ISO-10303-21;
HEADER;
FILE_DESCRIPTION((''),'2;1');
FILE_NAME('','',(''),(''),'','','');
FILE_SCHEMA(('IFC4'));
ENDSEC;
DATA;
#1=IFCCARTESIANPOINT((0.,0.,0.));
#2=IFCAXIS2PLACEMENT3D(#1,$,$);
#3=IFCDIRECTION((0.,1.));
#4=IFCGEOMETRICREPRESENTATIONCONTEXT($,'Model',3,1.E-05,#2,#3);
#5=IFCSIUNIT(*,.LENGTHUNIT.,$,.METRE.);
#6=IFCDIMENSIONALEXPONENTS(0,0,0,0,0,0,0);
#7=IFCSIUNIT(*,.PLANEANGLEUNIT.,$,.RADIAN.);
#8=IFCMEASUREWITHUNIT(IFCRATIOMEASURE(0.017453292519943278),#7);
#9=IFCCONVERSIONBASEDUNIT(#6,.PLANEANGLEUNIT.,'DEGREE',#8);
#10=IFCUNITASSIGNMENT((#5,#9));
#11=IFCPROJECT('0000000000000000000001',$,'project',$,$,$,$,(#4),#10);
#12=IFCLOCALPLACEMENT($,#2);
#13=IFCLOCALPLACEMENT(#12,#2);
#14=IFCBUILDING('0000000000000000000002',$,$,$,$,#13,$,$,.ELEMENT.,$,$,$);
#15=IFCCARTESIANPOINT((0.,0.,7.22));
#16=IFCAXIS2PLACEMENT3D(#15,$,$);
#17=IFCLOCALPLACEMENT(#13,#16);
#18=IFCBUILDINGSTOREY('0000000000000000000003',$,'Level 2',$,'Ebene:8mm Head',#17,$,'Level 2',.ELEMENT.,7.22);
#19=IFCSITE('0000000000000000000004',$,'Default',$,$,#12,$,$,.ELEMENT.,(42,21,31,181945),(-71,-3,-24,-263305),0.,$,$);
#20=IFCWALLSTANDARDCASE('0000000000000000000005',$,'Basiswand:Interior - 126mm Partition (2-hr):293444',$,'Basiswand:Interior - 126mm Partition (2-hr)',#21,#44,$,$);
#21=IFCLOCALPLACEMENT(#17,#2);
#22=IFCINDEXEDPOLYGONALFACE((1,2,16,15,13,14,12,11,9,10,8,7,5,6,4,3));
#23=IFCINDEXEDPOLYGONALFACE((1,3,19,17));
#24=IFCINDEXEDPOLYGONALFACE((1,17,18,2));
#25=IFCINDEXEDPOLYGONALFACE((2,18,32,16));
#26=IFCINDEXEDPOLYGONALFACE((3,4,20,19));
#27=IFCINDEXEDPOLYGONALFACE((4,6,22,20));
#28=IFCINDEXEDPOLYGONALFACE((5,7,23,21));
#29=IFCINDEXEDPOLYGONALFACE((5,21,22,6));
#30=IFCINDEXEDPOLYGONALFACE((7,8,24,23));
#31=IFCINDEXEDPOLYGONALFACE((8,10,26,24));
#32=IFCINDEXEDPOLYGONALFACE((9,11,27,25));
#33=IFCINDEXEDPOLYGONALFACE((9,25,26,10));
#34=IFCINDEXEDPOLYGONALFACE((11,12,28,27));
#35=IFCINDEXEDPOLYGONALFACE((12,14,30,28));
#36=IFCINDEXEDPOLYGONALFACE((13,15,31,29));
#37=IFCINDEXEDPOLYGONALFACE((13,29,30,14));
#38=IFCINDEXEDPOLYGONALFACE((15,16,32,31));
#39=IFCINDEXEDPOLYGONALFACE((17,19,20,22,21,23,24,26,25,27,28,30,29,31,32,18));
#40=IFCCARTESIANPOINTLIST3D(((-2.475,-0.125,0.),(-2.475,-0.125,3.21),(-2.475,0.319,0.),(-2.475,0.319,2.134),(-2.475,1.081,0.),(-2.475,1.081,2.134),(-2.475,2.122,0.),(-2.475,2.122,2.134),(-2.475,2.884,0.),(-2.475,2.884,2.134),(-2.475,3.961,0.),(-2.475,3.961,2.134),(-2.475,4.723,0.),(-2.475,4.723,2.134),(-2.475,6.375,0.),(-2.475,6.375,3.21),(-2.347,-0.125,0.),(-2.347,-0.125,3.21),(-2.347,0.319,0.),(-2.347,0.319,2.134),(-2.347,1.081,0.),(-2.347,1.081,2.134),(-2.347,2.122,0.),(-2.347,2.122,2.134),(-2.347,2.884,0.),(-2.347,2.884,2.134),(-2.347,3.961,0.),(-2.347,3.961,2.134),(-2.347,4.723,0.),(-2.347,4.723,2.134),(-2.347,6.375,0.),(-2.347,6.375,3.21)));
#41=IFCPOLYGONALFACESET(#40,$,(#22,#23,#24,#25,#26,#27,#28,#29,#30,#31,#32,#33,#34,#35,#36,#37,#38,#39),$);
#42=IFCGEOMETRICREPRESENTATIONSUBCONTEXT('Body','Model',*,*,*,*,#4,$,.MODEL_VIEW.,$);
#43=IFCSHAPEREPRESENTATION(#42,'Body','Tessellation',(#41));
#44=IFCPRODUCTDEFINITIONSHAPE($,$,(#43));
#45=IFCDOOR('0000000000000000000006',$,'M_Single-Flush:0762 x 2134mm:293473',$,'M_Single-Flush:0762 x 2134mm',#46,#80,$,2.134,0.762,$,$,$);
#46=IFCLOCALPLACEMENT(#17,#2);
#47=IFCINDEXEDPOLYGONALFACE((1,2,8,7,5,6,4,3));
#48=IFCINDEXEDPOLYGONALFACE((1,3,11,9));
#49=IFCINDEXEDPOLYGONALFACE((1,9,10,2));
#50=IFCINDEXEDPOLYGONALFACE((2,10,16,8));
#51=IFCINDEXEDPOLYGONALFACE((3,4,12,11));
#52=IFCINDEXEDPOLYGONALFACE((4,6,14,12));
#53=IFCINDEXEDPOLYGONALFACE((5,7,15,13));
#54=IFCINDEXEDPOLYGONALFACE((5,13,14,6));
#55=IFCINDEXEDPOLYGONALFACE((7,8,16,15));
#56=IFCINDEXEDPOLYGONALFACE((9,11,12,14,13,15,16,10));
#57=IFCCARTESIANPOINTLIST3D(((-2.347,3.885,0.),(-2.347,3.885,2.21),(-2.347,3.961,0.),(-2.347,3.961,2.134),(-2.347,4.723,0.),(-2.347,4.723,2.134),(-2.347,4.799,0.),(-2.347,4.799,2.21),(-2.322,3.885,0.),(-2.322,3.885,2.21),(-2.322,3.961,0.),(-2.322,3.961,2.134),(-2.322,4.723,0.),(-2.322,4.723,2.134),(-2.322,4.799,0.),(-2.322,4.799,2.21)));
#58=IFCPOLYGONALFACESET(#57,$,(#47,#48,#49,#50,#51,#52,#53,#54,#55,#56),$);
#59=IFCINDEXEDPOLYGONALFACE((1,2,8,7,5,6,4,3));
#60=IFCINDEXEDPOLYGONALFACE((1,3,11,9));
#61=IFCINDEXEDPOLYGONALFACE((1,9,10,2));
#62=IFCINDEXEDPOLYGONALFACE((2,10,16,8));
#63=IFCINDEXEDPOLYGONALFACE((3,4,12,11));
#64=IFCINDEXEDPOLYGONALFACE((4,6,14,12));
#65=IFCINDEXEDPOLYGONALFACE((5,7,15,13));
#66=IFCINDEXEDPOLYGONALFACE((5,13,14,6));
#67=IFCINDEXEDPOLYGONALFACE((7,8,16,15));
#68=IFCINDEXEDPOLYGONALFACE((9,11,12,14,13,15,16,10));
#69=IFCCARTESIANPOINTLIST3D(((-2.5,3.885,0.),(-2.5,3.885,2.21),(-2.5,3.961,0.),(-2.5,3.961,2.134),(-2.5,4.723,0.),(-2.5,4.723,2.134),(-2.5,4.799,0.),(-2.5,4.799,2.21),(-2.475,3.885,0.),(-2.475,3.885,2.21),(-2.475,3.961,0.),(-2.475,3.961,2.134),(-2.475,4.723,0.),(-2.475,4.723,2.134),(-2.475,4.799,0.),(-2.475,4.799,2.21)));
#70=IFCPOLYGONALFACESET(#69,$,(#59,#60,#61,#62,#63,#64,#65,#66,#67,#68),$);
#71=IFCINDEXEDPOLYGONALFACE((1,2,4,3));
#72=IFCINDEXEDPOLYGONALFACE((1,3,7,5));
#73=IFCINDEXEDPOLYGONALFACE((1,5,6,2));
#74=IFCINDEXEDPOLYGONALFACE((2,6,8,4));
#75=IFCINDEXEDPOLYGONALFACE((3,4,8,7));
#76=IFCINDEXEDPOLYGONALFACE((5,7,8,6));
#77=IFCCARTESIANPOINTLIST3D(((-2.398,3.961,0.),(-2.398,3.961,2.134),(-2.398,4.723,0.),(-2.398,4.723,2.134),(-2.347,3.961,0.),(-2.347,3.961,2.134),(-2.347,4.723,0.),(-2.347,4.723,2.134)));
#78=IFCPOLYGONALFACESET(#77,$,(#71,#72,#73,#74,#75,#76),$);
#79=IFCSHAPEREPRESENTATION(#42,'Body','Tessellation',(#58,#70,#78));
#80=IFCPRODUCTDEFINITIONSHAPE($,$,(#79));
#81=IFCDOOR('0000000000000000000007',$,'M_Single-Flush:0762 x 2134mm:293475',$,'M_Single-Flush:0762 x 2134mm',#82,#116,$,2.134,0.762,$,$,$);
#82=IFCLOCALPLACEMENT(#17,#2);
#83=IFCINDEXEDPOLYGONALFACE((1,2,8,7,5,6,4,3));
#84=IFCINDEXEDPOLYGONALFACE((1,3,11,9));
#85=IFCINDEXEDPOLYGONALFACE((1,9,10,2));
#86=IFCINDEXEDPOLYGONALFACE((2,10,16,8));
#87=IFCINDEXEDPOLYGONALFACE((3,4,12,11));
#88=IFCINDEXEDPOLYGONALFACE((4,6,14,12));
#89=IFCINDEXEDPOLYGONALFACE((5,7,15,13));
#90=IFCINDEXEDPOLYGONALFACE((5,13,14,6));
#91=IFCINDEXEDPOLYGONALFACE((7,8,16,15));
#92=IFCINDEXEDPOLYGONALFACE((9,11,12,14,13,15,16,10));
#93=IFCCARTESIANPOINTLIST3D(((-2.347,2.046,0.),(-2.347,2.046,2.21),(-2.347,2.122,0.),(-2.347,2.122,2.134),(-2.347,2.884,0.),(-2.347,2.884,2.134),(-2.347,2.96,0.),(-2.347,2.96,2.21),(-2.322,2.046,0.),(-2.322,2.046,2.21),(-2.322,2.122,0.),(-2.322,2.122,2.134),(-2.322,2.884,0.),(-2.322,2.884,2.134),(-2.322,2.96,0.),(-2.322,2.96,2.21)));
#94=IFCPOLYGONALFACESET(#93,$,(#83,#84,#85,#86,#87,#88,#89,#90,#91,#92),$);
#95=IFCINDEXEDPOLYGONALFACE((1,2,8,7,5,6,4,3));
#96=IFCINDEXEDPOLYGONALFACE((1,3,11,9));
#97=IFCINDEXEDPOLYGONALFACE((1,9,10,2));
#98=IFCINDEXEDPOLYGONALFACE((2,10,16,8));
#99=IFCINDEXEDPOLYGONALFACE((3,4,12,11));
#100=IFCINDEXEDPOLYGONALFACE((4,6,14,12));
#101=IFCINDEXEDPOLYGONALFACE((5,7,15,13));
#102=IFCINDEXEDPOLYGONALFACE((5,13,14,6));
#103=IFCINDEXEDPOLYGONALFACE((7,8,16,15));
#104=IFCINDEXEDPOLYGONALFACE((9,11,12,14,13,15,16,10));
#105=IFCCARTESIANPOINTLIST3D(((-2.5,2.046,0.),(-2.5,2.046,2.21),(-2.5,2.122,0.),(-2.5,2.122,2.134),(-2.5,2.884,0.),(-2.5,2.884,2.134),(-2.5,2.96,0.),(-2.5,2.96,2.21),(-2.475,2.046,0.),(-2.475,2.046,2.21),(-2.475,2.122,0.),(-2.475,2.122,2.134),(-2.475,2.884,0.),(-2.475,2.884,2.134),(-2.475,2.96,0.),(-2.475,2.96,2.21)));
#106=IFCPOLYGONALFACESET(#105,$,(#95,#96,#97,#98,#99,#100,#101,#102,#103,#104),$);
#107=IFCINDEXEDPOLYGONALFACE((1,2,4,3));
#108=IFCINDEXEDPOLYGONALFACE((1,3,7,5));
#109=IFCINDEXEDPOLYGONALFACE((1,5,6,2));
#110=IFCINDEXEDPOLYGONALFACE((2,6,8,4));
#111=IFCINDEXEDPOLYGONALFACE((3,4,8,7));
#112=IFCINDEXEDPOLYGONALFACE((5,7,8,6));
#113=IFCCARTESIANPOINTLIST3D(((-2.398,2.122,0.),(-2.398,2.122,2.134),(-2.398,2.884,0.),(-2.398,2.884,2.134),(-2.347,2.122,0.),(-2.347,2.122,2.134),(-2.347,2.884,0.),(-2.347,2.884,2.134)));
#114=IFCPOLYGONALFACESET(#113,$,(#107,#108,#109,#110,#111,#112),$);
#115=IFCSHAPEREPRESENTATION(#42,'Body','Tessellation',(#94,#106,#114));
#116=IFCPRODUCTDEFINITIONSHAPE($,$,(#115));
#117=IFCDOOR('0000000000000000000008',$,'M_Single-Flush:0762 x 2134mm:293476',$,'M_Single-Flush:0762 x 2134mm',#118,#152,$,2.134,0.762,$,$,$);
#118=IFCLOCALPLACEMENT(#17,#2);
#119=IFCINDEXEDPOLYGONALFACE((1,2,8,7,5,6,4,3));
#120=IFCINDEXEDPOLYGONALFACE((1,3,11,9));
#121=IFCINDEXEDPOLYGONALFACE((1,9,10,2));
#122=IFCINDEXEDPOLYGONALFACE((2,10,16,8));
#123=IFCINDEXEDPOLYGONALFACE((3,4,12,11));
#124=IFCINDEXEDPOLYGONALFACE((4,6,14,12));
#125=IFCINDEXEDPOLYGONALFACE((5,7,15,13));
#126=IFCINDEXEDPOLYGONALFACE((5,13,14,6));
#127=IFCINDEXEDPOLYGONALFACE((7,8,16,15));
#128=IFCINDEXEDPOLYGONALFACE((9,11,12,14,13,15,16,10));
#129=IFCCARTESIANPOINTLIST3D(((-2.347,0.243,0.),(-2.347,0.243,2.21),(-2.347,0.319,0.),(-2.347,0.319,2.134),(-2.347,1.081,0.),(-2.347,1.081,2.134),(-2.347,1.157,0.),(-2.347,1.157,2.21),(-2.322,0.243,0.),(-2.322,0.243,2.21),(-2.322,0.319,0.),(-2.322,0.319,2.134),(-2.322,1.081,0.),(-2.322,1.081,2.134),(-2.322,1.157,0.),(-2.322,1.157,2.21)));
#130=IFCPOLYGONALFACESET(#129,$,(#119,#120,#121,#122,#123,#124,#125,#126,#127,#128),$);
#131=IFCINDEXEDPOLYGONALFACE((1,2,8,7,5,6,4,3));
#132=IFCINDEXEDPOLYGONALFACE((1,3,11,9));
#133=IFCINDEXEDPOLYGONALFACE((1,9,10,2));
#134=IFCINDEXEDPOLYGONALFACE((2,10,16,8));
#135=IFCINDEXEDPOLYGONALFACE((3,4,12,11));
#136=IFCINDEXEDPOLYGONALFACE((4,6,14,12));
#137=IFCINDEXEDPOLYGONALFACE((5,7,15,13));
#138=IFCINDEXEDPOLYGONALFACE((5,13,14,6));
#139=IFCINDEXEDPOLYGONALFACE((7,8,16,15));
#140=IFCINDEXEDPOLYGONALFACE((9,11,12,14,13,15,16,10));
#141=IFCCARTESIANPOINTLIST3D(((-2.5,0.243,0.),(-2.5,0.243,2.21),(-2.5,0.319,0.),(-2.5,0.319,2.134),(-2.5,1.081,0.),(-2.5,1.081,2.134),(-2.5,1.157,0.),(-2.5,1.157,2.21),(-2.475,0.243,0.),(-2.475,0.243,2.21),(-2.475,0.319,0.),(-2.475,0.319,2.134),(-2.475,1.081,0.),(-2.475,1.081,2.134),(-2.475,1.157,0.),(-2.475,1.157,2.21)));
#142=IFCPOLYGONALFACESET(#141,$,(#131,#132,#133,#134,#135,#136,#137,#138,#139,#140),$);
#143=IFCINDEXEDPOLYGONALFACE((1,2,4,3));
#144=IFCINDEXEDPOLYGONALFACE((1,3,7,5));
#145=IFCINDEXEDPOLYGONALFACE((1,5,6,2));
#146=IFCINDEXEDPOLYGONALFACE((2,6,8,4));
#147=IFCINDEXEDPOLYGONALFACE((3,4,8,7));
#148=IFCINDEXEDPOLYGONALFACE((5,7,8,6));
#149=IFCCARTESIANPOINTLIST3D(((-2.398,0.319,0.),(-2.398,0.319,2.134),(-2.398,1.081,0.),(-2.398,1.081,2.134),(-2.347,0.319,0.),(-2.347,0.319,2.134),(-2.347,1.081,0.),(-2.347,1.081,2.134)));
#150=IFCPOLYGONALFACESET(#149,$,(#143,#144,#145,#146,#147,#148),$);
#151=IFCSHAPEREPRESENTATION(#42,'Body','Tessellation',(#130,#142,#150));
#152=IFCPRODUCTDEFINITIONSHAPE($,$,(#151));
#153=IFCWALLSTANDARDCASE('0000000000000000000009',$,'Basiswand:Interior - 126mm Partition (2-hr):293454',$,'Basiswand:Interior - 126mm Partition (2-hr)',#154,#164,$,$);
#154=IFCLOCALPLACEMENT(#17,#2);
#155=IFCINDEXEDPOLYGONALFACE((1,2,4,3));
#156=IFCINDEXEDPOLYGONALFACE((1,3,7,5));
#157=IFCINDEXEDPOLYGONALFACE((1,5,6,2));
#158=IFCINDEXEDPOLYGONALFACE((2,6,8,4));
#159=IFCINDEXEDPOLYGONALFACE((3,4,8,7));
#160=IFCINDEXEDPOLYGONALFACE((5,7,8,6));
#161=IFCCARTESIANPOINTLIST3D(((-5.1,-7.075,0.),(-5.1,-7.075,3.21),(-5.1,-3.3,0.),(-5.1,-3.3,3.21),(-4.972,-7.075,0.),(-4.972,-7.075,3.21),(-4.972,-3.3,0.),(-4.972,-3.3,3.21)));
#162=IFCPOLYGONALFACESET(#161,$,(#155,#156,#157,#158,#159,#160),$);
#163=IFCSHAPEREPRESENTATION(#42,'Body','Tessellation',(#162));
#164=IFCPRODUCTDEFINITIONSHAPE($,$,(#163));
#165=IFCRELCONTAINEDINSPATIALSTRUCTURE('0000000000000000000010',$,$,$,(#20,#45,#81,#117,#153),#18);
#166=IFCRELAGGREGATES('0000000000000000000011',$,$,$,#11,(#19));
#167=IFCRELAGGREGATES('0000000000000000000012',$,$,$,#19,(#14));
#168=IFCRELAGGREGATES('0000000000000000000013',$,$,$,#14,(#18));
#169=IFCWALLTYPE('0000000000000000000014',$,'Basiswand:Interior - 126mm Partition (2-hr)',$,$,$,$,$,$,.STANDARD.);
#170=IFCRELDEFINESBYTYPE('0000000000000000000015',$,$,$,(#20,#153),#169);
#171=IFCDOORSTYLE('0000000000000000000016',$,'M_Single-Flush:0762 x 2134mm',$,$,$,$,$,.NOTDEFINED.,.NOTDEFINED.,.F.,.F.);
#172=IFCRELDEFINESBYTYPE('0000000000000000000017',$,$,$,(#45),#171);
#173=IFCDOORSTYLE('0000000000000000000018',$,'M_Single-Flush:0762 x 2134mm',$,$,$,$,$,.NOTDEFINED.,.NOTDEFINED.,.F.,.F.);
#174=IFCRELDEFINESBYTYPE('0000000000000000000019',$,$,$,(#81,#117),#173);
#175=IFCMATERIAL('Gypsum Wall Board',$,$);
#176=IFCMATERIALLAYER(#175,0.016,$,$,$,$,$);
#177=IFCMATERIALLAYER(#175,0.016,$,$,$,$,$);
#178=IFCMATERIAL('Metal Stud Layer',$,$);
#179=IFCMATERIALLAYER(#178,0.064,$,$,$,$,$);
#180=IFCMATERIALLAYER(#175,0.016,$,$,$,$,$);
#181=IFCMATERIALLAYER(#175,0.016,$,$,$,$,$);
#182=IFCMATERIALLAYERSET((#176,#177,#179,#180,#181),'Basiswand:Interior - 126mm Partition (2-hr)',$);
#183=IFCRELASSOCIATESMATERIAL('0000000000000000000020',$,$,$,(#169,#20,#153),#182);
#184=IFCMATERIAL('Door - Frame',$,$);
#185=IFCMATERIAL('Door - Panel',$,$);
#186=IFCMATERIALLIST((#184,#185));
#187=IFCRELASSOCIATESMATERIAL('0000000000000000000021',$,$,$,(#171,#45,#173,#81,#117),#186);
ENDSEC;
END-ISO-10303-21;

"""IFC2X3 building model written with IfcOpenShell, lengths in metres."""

from ifc_helpers import new_model, entity, si_unit, converted_unit, direction, frame, frame_2d, origin, place, context, subcontext, project, spatial, polyline, rectangle, outline, extrude, clip, bounded_halfspace, source, transform, mapped, material, material_list, layer, layer_set, layer_usage, type_object, type_shapes, element, fill, save


model = new_model("IFC2X3")

# Units and contexts
model_context = context("Model", 3, precision=1e-05, world=origin(), true_north=direction((0.0, 1.0)))
body_context = subcontext(model_context, "Body", "Model", "MODEL_VIEW")
ifc_project = project(units=[si_unit("LENGTHUNIT", "METRE"), converted_unit("PLANEANGLEUNIT", "DEGREE", entity("IfcRatioMeasure", 0.017453292519943278), si_unit("PLANEANGLEUNIT", "RADIAN"), dimensions=[0, 0, 0, 0, 0, 0, 0])], contexts=[model_context])

# Site, building, storey
site_placement = place(None, origin())
site = spatial("IfcSite", under=ifc_project, at=site_placement, Name="Default", CompositionType="ELEMENT", RefLatitude=(42, 21, 31, 181945), RefLongitude=(-71, -3, -24, -263305), RefElevation=0.0)
building_placement = place(site_placement, origin())
building = spatial("IfcBuilding", under=site, at=building_placement, CompositionType="ELEMENT")
storey_placement = place(building_placement, frame((0.0, 0.0, 7.22)))
storey = spatial("IfcBuildingStorey", under=building, at=storey_placement, Name="Level 2", ObjectType="Ebene:8mm Head", LongName="Level 2", CompositionType="ELEMENT", Elevation=7.22)

# Shared definitions
ifc_material_1 = material(Name="Gypsum Wall Board")
ifc_layer_1 = layer(ifc_material_1, 0.016)
ifc_layer_2 = layer(ifc_material_1, 0.016)
ifc_material_2 = material(Name="Metal Stud Layer")
ifc_layer_3 = layer(ifc_material_2, 0.064)
ifc_layer_4 = layer(ifc_material_1, 0.016)
ifc_layer_5 = layer(ifc_material_1, 0.016)
ifc_layer_set_1 = layer_set([ifc_layer_1, ifc_layer_2, ifc_layer_3, ifc_layer_4, ifc_layer_5], Name="Basiswand:Interior - 126mm Partition (2-hr)")
wall_type_1 = type_object("IfcWallType", Name="Basiswand:Interior - 126mm Partition (2-hr)", PredefinedType="STANDARD", material=ifc_layer_set_1)
ifc_material_3 = material(Name="Door - Frame")
ifc_material_4 = material(Name="Door - Panel")
ifc_material_list = material_list([ifc_material_3, ifc_material_4])

# Wall, openings, doors
ifc_layer_usage_1 = layer_usage(ifc_layer_set_1, "AXIS2", "NEGATIVE", 0.064)
wall_1_placement = place(storey_placement, frame((-2.411, -0.125, 0.0), z_axis=(0.0, 0.0, 1.0), x_axis=(0.0, 1.0, 0.0)))
wall_1 = element("IfcWallStandardCase", 1, at=wall_1_placement, inside=storey, type_object=wall_type_1, material=ifc_layer_usage_1, Name="Basiswand:Interior - 126mm Partition (2-hr):293444", ObjectType="Basiswand:Interior - 126mm Partition (2-hr)", context=body_context, shape_type="Clipping", body=[
    clip(extrude(rectangle(XDim=6.5, YDim=0.128, at=frame_2d((3.25, 0.0), x_axis=(1.0, 0.0))), origin(), (0.0, 0.0, 1.0), 3.21), bounded_halfspace(frame((0.0, -0.064, 3.21), z_axis=(0.0, 0.0, -1.0), x_axis=(1.0, 0.0, 0.0)), True, frame((0.0, -0.064, 3.21)), polyline([(0.0, 0.0), (2.0, 0.0), (2.128, 0.0), (3.128, 0.0), (3.256, 0.0), (5.103, 0.0), (5.231, 0.0), (6.5, 0.0), (6.5, 0.128), (0.0, 0.128), (0.0, 0.0)]))),
])
opening_1_placement = place(wall_1_placement, frame((4.848, 0.064, 0.0)))
opening_1 = element("IfcOpeningElement", 2, at=opening_1_placement, cuts=wall_1, ObjectType="Opening", context=body_context, shape_type="SweptSolid", body=[
    extrude(rectangle(XDim=0.762, YDim=2.134, at=frame_2d((1.067, 0.381), x_axis=(0.0, -1.0))), frame((0.0, 0.0, 0.0), z_axis=(0.0, -1.0, 0.0), x_axis=(0.0, 0.0, 1.0)), (0.0, 0.0, 1.0), 0.128),
])
opening_2_placement = place(wall_1_placement, frame((3.009, 0.064, 0.0)))
opening_2 = element("IfcOpeningElement", 3, at=opening_2_placement, cuts=wall_1, ObjectType="Opening", context=body_context, shape_type="SweptSolid", body=[
    extrude(rectangle(XDim=0.762, YDim=2.134, at=frame_2d((1.067, 0.381), x_axis=(0.0, 1.0))), frame((0.0, 0.0, 0.0), z_axis=(0.0, -1.0, 0.0), x_axis=(0.0, 0.0, 1.0)), (0.0, 0.0, 1.0), 0.128),
])
opening_3_placement = place(wall_1_placement, frame((1.206, 0.064, 0.0)))
opening_3 = element("IfcOpeningElement", 4, at=opening_3_placement, cuts=wall_1, ObjectType="Opening", context=body_context, shape_type="SweptSolid", body=[
    extrude(rectangle(XDim=0.762, YDim=2.134, at=frame_2d((1.067, 0.381), x_axis=(0.0, 1.0))), frame((0.0, 0.0, 0.0), z_axis=(0.0, -1.0, 0.0), x_axis=(0.0, 0.0, 1.0)), (0.0, 0.0, 1.0), 0.128),
])
door_style_1 = type_object("IfcDoorStyle", Name="M_Single-Flush:0762 x 2134mm", ConstructionType="NOTDEFINED", OperationType="NOTDEFINED", ParameterTakesPrecedence=False, Sizeable=False, material=ifc_material_list)
shared_shape_1 = source(origin(), body_context, "Body", "SweptSolid", [
    extrude(outline(polyline([(-0.457, -1.124), (0.457, -1.124), (0.457, 1.086), (0.381, 1.086), (0.381, -1.048), (-0.381, -1.048), (-0.381, 1.086), (-0.457, 1.086), (-0.457, -1.124)])), frame((0.381, 0.153, 1.086), z_axis=(0.0, -1.0, 0.0), x_axis=(-1.0, 0.0, 0.0)), (0.0, 0.0, 1.0), 0.025),
    extrude(outline(polyline([(-1.124, -0.457), (1.086, -0.457), (1.086, -0.381), (-1.048, -0.381), (-1.048, 0.381), (1.086, 0.381), (1.086, 0.457), (-1.124, 0.457), (-1.124, -0.457)])), frame((0.381, 0.0, 1.086), z_axis=(0.0, -1.0, 0.0), x_axis=(0.0, 0.0, -1.0)), (0.0, 0.0, 1.0), 0.025),
    extrude(rectangle(XDim=0.762, YDim=0.051, at=frame_2d((0.0, 0.0), x_axis=(1.0, 0.0))), frame((0.381, 0.1025, 0.0)), (0.0, 0.0, 1.0), 2.134),
])
type_shapes(door_style_1, [shared_shape_1])
door_1_placement = place(opening_1_placement, frame((0.0, 0.0, 0.0), z_axis=(0.0, 0.0, 1.0), x_axis=(-1.0, 0.0, 0.0)))
door_1 = element("IfcDoor", 5, at=door_1_placement, inside=storey, type_object=door_style_1, material=ifc_material_list, Name="M_Single-Flush:0762 x 2134mm:293473", ObjectType="M_Single-Flush:0762 x 2134mm", OverallHeight=2.134, OverallWidth=0.762, context=body_context, shape_type="MappedRepresentation", body=[
    mapped(shared_shape_1, transform((0.0, 0.0, 0.0), scale=1.0)),
])
fill(opening_1, door_1)
door_style_2 = type_object("IfcDoorStyle", Name="M_Single-Flush:0762 x 2134mm", ConstructionType="NOTDEFINED", OperationType="NOTDEFINED", ParameterTakesPrecedence=False, Sizeable=False, material=ifc_material_list)
shared_shape_2 = source(origin(), body_context, "Body", "SweptSolid", [
    extrude(outline(polyline([(-0.457, -1.124), (0.457, -1.124), (0.457, 1.086), (0.381, 1.086), (0.381, -1.048), (-0.381, -1.048), (-0.381, 1.086), (-0.457, 1.086), (-0.457, -1.124)])), frame((0.381, 0.128, 1.086), z_axis=(0.0, 1.0, 0.0), x_axis=(1.0, 0.0, 0.0)), (0.0, 0.0, 1.0), 0.025),
    extrude(outline(polyline([(-1.124, -0.457), (1.086, -0.457), (1.086, -0.381), (-1.048, -0.381), (-1.048, 0.381), (1.086, 0.381), (1.086, 0.457), (-1.124, 0.457), (-1.124, -0.457)])), frame((0.381, -0.025, 1.086), z_axis=(0.0, 1.0, 0.0), x_axis=(0.0, 0.0, -1.0)), (0.0, 0.0, 1.0), 0.025),
    extrude(rectangle(XDim=0.051, YDim=0.762, at=frame_2d((0.0, 0.0), x_axis=(1.0, 0.0))), frame((0.381, 0.1025, 0.0), z_axis=(0.0, 0.0, 1.0), x_axis=(0.0, 1.0, 0.0)), (0.0, 0.0, 1.0), 2.134),
])
type_shapes(door_style_2, [shared_shape_2])
door_2_placement = place(opening_2_placement, frame((0.0, 0.0, 0.0), z_axis=(0.0, 0.0, 1.0), x_axis=(-1.0, 0.0, 0.0)))
door_2 = element("IfcDoor", 6, at=door_2_placement, inside=storey, type_object=door_style_2, material=ifc_material_list, Name="M_Single-Flush:0762 x 2134mm:293475", ObjectType="M_Single-Flush:0762 x 2134mm", OverallHeight=2.134, OverallWidth=0.762, context=body_context, shape_type="MappedRepresentation", body=[
    mapped(shared_shape_2, transform((0.0, 0.0, 0.0), scale=1.0)),
])
fill(opening_2, door_2)
door_3_placement = place(opening_3_placement, frame((0.0, 0.0, 0.0), z_axis=(0.0, 0.0, 1.0), x_axis=(-1.0, 0.0, 0.0)))
door_3 = element("IfcDoor", 7, at=door_3_placement, inside=storey, type_object=door_style_2, material=ifc_material_list, Name="M_Single-Flush:0762 x 2134mm:293476", ObjectType="M_Single-Flush:0762 x 2134mm", OverallHeight=2.134, OverallWidth=0.762, context=body_context, shape_type="MappedRepresentation", body=[
    mapped(shared_shape_2, transform((0.0, 0.0, 0.0), scale=1.0)),
])
fill(opening_3, door_3)

# Wall
wall_2_placement = place(storey_placement, frame((-5.036, -7.075, 0.0), z_axis=(0.0, 0.0, 1.0), x_axis=(0.0, 1.0, 0.0)))
element("IfcWallStandardCase", 8, at=wall_2_placement, inside=storey, type_object=wall_type_1, material=ifc_layer_usage_1, Name="Basiswand:Interior - 126mm Partition (2-hr):293454", ObjectType="Basiswand:Interior - 126mm Partition (2-hr)", context=body_context, shape_type="Clipping", body=[
    clip(extrude(rectangle(XDim=3.775, YDim=0.128, at=frame_2d((1.8875, 0.0), x_axis=(-1.0, 0.0))), origin(), (0.0, 0.0, 1.0), 3.21), bounded_halfspace(frame((0.0, -0.064, 3.21), z_axis=(0.0, 0.0, -1.0), x_axis=(1.0, 0.0, 0.0)), True, frame((0.0, -0.064, 3.21)), polyline([(0.0, 0.0), (3.647, 0.0), (3.775, 0.0), (3.775, 0.128), (0.0, 0.128), (0.0, 0.0)]))),
])

save(model, "model.ifc")
